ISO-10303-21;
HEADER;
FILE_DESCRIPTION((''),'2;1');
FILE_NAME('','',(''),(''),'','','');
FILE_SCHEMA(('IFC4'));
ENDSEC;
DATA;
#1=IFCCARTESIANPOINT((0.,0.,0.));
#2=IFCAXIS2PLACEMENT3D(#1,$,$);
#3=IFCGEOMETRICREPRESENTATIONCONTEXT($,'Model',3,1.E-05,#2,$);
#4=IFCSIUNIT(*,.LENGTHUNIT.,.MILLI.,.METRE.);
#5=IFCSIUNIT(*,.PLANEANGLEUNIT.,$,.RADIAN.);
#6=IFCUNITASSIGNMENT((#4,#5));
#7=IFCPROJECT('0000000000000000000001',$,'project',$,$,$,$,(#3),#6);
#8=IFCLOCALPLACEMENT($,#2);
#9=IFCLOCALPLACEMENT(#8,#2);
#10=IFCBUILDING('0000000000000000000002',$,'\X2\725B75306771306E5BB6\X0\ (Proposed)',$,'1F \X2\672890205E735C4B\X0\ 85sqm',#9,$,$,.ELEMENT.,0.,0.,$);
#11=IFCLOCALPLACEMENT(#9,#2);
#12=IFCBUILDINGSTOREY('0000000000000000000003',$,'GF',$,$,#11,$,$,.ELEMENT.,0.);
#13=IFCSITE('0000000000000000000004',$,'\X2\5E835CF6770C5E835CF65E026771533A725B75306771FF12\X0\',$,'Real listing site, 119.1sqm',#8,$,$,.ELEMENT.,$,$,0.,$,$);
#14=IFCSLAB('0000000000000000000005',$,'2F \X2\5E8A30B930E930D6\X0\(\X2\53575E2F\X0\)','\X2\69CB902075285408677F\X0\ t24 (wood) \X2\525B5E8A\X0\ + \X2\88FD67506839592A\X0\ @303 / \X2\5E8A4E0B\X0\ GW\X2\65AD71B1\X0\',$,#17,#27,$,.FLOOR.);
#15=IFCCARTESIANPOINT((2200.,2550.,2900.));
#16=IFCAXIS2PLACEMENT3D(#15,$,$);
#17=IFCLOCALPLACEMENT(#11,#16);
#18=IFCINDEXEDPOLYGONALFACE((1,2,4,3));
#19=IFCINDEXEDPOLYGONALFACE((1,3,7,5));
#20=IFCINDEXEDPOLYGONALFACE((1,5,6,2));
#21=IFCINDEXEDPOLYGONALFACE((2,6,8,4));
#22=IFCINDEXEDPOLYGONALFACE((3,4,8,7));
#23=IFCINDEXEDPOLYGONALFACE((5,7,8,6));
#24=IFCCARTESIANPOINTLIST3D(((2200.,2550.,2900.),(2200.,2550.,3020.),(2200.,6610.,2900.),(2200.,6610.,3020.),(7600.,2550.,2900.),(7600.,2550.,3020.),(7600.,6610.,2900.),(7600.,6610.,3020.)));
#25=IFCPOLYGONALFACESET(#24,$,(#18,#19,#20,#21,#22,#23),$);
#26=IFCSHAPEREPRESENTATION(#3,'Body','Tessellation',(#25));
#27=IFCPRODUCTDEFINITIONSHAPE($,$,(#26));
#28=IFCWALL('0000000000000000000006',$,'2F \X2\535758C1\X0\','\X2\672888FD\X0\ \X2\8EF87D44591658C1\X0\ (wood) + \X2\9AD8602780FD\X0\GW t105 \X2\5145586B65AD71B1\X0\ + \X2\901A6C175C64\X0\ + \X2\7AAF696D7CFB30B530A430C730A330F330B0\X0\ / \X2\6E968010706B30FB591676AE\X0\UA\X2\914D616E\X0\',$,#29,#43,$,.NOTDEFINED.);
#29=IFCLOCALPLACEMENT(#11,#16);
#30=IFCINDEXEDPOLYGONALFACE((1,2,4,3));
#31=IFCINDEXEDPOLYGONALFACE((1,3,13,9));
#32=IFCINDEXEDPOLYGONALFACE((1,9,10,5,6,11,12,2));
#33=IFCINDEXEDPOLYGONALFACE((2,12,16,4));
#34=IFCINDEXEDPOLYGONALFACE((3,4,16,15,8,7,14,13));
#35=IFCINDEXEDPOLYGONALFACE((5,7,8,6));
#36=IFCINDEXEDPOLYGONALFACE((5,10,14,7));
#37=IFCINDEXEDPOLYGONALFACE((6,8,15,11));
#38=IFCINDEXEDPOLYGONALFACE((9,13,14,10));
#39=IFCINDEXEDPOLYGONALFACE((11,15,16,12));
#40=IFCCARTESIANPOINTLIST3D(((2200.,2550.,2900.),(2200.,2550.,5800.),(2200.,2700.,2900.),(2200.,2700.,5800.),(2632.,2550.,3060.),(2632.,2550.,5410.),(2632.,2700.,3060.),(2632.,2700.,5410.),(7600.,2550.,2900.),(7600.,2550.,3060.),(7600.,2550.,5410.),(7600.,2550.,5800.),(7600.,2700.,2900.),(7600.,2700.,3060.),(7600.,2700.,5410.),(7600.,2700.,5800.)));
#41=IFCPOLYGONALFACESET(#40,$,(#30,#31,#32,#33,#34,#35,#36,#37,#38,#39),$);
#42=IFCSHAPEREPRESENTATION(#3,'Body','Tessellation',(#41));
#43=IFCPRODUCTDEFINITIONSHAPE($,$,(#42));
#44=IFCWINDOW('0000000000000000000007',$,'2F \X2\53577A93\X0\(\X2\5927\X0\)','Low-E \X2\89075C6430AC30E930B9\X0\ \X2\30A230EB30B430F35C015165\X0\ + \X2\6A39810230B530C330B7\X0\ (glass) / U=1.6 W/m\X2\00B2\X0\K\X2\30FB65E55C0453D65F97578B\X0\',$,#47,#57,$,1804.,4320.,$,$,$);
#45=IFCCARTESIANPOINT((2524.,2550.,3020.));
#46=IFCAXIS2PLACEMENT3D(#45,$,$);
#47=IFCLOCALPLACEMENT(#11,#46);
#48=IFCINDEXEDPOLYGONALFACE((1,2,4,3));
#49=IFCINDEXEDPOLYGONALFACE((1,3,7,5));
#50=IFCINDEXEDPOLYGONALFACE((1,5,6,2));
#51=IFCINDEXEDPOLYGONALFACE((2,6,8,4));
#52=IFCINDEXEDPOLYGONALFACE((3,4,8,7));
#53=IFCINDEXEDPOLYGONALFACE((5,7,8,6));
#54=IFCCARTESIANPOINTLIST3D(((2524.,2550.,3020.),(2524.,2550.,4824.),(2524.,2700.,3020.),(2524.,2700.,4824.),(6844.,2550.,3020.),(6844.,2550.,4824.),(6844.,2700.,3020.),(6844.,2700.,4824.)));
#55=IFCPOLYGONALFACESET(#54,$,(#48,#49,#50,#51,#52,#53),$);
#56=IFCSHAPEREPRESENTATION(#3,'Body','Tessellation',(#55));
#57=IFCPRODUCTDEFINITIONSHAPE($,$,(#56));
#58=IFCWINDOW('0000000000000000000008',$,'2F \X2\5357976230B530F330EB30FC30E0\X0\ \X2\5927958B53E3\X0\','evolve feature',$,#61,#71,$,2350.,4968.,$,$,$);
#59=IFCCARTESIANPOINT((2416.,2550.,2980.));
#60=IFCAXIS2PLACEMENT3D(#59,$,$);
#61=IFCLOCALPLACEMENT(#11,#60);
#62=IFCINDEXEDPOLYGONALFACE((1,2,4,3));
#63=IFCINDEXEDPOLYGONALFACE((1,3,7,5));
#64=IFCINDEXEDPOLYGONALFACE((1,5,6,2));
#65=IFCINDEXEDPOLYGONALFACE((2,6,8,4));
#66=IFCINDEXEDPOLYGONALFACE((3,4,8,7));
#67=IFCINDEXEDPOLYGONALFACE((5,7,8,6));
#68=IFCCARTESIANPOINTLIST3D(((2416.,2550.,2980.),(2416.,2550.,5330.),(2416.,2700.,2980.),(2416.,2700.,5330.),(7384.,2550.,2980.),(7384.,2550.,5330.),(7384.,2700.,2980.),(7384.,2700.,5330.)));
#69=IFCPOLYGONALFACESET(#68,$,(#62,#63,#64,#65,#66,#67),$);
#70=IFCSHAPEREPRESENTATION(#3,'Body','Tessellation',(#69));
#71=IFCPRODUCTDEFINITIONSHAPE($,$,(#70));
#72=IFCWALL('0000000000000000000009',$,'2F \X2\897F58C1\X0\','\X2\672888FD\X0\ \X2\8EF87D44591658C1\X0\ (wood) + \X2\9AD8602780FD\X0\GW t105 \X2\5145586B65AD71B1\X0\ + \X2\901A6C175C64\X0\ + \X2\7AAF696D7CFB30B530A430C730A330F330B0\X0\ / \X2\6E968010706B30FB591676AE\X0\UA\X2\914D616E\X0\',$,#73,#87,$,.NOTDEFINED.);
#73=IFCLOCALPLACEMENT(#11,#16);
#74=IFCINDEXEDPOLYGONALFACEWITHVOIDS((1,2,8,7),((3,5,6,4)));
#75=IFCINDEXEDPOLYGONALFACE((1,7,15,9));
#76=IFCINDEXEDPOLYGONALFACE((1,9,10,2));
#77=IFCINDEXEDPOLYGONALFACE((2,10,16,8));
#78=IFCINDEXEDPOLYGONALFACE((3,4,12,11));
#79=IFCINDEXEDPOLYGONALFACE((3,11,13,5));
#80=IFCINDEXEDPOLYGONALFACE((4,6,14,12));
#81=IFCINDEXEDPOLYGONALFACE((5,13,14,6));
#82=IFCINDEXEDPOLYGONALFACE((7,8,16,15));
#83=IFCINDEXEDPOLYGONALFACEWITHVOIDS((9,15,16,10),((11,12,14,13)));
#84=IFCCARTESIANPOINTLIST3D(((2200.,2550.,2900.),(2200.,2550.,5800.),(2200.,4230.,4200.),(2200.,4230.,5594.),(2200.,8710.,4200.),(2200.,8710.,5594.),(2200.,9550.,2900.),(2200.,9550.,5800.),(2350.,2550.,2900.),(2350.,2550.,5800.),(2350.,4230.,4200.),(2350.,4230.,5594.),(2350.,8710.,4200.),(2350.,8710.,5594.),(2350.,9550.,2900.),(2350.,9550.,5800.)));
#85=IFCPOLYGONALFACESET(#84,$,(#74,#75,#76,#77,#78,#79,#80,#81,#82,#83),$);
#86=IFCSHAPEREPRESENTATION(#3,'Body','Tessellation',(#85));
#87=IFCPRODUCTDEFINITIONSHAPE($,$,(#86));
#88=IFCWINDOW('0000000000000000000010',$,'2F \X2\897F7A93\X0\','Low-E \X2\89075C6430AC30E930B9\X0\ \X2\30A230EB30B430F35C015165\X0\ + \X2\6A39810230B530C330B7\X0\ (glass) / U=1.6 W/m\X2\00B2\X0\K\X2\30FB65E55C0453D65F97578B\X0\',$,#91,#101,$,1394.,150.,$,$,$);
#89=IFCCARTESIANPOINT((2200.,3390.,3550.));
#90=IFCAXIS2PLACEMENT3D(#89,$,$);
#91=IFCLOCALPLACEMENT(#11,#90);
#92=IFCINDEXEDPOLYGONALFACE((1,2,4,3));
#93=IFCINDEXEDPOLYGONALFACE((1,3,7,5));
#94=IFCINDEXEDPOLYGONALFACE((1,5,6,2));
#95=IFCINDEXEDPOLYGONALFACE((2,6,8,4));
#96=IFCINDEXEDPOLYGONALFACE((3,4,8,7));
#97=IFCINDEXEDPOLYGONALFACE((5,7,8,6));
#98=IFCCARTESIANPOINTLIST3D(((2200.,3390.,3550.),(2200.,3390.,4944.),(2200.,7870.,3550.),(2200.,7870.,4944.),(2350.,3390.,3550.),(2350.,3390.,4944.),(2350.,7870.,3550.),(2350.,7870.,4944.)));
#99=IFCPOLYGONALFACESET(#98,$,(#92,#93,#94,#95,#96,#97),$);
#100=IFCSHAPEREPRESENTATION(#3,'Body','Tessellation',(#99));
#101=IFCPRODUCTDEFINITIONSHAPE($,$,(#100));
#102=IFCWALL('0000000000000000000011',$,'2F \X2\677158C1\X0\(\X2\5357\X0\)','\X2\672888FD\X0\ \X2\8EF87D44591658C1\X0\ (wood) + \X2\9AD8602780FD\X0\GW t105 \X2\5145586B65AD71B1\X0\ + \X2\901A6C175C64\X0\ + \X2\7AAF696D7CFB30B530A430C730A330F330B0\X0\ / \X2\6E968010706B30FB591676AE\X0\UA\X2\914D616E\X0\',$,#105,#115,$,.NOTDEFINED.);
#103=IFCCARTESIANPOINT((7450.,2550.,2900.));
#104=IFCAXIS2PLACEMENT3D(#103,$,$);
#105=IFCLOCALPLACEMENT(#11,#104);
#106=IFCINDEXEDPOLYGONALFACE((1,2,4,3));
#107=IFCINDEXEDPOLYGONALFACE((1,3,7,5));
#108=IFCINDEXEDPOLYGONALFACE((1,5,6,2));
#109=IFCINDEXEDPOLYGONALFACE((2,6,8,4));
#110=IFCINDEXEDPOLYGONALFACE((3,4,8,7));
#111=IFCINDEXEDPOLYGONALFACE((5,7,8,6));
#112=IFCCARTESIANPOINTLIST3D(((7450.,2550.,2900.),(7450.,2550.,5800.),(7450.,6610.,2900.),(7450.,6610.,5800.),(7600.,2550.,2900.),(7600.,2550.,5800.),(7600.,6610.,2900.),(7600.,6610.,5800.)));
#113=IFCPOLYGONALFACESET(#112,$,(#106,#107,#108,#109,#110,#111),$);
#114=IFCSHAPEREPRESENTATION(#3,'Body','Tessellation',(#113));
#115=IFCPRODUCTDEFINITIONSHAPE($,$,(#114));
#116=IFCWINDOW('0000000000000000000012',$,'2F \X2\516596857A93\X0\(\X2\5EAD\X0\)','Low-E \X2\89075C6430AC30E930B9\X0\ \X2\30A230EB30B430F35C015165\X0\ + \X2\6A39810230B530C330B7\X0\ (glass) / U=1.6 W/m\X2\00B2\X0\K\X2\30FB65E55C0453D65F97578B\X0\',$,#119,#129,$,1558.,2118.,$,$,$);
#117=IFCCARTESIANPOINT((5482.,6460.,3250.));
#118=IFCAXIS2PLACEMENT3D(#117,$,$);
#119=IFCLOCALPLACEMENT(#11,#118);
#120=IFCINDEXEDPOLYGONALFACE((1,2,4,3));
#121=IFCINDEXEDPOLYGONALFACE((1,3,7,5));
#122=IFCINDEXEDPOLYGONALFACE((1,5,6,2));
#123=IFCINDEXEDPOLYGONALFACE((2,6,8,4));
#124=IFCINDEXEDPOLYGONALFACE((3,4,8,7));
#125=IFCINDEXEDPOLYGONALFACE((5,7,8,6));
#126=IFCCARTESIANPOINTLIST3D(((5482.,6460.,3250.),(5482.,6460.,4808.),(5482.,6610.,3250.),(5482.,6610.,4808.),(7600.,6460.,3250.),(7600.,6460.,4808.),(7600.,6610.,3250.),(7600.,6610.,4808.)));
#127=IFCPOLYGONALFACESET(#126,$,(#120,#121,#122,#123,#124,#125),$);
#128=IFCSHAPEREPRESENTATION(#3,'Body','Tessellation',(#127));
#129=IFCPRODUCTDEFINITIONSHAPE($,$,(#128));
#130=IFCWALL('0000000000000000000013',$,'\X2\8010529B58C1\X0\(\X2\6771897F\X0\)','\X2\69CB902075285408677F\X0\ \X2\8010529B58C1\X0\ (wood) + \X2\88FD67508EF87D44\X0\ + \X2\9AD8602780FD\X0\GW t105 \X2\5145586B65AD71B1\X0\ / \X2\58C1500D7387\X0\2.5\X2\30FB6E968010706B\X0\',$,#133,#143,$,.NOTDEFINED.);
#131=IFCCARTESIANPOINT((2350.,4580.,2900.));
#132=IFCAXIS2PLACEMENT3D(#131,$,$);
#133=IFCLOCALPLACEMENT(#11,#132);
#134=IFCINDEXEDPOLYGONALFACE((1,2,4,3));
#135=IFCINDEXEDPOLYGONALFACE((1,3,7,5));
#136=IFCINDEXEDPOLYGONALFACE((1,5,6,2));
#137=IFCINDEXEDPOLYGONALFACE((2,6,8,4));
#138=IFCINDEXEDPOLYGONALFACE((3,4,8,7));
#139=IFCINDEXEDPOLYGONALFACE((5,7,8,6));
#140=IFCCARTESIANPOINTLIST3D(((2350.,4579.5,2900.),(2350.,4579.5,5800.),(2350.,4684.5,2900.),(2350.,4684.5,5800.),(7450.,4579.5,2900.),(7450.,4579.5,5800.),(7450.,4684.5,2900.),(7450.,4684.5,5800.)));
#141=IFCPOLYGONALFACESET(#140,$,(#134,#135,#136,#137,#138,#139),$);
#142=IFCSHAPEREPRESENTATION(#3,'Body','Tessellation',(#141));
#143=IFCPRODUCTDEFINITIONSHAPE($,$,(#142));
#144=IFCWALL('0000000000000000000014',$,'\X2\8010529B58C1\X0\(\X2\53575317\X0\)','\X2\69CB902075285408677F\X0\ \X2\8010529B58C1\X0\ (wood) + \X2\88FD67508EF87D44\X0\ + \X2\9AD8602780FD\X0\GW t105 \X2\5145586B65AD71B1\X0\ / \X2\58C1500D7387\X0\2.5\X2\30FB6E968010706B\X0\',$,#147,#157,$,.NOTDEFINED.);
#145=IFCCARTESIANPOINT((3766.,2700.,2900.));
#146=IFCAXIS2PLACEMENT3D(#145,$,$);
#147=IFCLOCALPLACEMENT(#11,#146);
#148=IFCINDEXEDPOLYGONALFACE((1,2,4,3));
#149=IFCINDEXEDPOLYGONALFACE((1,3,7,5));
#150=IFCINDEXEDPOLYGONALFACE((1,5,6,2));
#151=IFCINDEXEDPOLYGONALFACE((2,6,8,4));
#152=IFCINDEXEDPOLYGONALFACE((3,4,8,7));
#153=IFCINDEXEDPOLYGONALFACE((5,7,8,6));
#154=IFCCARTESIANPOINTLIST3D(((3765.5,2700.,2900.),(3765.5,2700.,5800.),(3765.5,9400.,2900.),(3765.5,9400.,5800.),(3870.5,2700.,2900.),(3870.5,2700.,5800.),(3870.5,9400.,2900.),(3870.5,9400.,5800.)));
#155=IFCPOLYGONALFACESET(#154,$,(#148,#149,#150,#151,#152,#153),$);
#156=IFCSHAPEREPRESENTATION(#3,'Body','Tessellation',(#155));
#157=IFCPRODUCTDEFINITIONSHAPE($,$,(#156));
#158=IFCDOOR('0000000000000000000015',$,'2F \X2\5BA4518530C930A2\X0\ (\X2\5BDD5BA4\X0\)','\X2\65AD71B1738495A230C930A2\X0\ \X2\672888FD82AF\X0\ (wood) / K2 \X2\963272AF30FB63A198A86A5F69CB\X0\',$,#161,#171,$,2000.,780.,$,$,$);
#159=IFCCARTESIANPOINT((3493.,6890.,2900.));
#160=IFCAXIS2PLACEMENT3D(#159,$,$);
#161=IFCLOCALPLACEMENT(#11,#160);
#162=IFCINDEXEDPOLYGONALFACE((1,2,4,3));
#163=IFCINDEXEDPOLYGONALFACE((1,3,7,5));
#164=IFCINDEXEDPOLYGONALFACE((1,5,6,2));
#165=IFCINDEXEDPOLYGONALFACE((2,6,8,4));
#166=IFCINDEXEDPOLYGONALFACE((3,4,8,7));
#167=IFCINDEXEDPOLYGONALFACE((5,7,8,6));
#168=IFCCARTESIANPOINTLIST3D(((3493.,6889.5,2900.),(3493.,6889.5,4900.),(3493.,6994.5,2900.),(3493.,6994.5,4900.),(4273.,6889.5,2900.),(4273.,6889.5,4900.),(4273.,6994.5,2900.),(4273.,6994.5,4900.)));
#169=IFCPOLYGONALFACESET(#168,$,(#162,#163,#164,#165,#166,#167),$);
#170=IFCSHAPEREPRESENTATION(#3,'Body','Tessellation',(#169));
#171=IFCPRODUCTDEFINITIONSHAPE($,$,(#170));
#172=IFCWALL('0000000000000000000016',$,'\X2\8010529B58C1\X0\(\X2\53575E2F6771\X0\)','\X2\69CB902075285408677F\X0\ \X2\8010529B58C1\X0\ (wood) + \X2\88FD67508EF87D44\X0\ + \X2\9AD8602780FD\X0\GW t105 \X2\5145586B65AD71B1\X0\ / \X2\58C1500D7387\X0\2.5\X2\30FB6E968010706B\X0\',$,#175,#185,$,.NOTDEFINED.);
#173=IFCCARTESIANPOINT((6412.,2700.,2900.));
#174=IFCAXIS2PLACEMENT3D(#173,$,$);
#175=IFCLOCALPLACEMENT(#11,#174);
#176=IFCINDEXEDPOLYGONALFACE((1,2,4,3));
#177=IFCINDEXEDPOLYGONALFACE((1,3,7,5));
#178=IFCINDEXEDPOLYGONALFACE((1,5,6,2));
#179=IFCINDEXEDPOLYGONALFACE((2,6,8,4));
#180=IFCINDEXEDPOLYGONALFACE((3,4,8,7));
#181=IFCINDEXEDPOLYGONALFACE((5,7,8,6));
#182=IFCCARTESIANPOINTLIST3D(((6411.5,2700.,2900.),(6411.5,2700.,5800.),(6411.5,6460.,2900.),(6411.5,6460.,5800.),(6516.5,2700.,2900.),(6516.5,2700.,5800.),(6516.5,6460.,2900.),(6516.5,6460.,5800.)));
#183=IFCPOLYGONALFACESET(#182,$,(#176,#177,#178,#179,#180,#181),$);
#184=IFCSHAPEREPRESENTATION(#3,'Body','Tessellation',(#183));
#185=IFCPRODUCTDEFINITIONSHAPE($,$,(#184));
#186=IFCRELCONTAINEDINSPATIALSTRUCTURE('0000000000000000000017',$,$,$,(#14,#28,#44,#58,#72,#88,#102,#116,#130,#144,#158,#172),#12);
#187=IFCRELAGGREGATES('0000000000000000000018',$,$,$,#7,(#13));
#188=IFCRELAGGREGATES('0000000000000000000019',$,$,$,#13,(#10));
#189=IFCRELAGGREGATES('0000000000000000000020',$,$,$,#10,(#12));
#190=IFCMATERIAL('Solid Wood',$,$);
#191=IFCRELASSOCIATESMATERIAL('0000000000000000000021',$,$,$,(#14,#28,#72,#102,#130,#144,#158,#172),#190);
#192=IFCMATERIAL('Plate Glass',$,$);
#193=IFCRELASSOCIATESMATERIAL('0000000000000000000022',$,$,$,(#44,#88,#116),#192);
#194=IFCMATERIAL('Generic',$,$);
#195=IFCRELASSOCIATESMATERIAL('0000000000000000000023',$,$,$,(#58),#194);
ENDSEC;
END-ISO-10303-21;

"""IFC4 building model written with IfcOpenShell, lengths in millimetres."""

from ifc_helpers import new_model, si_unit, frame, frame_2d, origin, place, context, project, spatial, rectangle, extrude, material, element, fill, save


model = new_model("IFC4")

# Units and contexts
model_context = context("Model", 3, precision=1e-05, world=origin())
ifc_project = project(units=[si_unit("LENGTHUNIT", "METRE", prefix="MILLI"), si_unit("PLANEANGLEUNIT", "RADIAN")], contexts=[model_context])

# Site, building, storey
site_placement = place(None, origin())
site = spatial("IfcSite", under=ifc_project, at=site_placement, Name="広島県広島市東区牛田東２", ObjectType="Real listing site, 119.1sqm", CompositionType="ELEMENT", RefElevation=0.0)
building_placement = place(site_placement, origin())
building = spatial("IfcBuilding", under=site, at=building_placement, Name="牛田東の家 (Proposed)", ObjectType="1F 木造平屋 85sqm", CompositionType="ELEMENT", ElevationOfRefHeight=0.0, ElevationOfTerrain=0.0)
storey_placement = place(building_placement, origin())
storey = spatial("IfcBuildingStorey", under=building, at=storey_placement, Name="GF", CompositionType="ELEMENT", Elevation=0.0)

# Slab
ifc_material_1 = material(Name="Solid Wood")
slab_placement = place(storey_placement, frame((2200.0, 2550.0, 2900.0)))
element("IfcSlab", 1, at=slab_placement, inside=storey, material=ifc_material_1, Name="2F 床スラブ(南帯)", Description="構造用合板 t24 (wood) 剛床 + 製材根太 @303 / 床下 GW断熱", PredefinedType="FLOOR", context=model_context, shape_type="SweptSolid", body=[
    extrude(rectangle(XDim=5400.0, YDim=4060.0, at=frame_2d((2700.0, 2030.0))), frame((2200.0, 2550.0, 2900.0)), (0.0, 0.0, 1.0), 120.0),
])

# Wall, openings, windows
wall_1_placement = place(storey_placement, frame((2200.0, 2550.0, 2900.0)))
wall_1 = element("IfcWall", 2, at=wall_1_placement, inside=storey, material=ifc_material_1, Name="2F 南壁", Description="木製 軸組外壁 (wood) + 高性能GW t105 充填断熱 + 通気層 + 窯業系サイディング / 準耐火・外皮UA配慮", PredefinedType="NOTDEFINED", context=model_context, shape_type="SweptSolid", body=[
    extrude(rectangle(XDim=5400.0, YDim=150.0, at=frame_2d((2700.0, 75.0))), frame((2200.0, 2550.0, 2900.0)), (0.0, 0.0, 1.0), 2900.0),
])
opening_1_placement = place(storey_placement, frame((2524.0, 2550.0, 3020.0)))
opening_1 = element("IfcOpeningElement", 3, at=opening_1_placement, cuts=wall_1, PredefinedType="NOTDEFINED", context=model_context, shape_type="SweptSolid", body=[
    extrude(rectangle(XDim=4320.0, YDim=150.0, at=frame_2d((2160.0, 75.0))), frame((2524.0, 2550.0, 3020.0)), (0.0, 0.0, 1.0), 1804.0),
])
opening_2_placement = place(storey_placement, frame((2416.0, 2550.0, 2980.0)))
opening_2 = element("IfcOpeningElement", 4, at=opening_2_placement, cuts=wall_1, PredefinedType="NOTDEFINED", context=model_context, shape_type="SweptSolid", body=[
    extrude(rectangle(XDim=4968.0, YDim=150.0, at=frame_2d((2484.0, 75.0))), frame((2416.0, 2550.0, 2980.0)), (0.0, 0.0, 1.0), 2350.0),
])
ifc_material_2 = material(Name="Plate Glass")
window_1_placement = place(storey_placement, frame((2524.0, 2550.0, 3020.0)))
window_1 = element("IfcWindow", 5, at=window_1_placement, inside=storey, material=ifc_material_2, Name="2F 南窓(大)", Description="Low-E 複層ガラス アルゴン封入 + 樹脂サッシ (glass) / U=1.6 W/m²K・日射取得型", OverallHeight=1804.0, OverallWidth=4320.0, context=model_context, shape_type="SweptSolid", body=[
    extrude(rectangle(XDim=4320.0, YDim=150.0, at=frame_2d((2160.0, 75.0))), frame((2524.0, 2550.0, 3020.0)), (0.0, 0.0, 1.0), 1804.0),
])
fill(opening_1, window_1)
ifc_material_3 = material(Name="Generic")
window_2_placement = place(storey_placement, frame((2416.0, 2550.0, 2980.0)))
window_2 = element("IfcWindow", 6, at=window_2_placement, inside=storey, material=ifc_material_3, Name="2F 南面サンルーム 大開口", Description="evolve feature", OverallHeight=2350.0, OverallWidth=4968.0, context=model_context, shape_type="SweptSolid", body=[
    extrude(rectangle(XDim=4968.0, YDim=150.0, at=frame_2d((2484.0, 75.0))), frame((2416.0, 2550.0, 2980.0)), (0.0, 0.0, 1.0), 2350.0),
])
fill(opening_2, window_2)

# Walls, openings, windows
wall_2_placement = place(storey_placement, frame((2200.0, 2550.0, 2900.0)))
wall_2 = element("IfcWall", 7, at=wall_2_placement, inside=storey, material=ifc_material_1, Name="2F 西壁", Description="木製 軸組外壁 (wood) + 高性能GW t105 充填断熱 + 通気層 + 窯業系サイディング / 準耐火・外皮UA配慮", PredefinedType="NOTDEFINED", context=model_context, shape_type="SweptSolid", body=[
    extrude(rectangle(XDim=150.0, YDim=7000.0, at=frame_2d((75.0, 3500.0))), frame((2200.0, 2550.0, 2900.0)), (0.0, 0.0, 1.0), 2900.0),
])
opening_3_placement = place(storey_placement, frame((2200.0, 3390.0, 3550.0)))
opening_3 = element("IfcOpeningElement", 8, at=opening_3_placement, cuts=wall_2, PredefinedType="NOTDEFINED", context=model_context, shape_type="SweptSolid", body=[
    extrude(rectangle(XDim=150.0, YDim=4480.0, at=frame_2d((75.0, 2240.0))), frame((2200.0, 3390.0, 3550.0)), (0.0, 0.0, 1.0), 1394.0),
])
window_3_placement = place(storey_placement, frame((2200.0, 3390.0, 3550.0)))
window_3 = element("IfcWindow", 9, at=window_3_placement, inside=storey, material=ifc_material_2, Name="2F 西窓", Description="Low-E 複層ガラス アルゴン封入 + 樹脂サッシ (glass) / U=1.6 W/m²K・日射取得型", OverallHeight=1394.0, OverallWidth=150.0, context=model_context, shape_type="SweptSolid", body=[
    extrude(rectangle(XDim=150.0, YDim=4480.0, at=frame_2d((75.0, 2240.0))), frame((2200.0, 3390.0, 3550.0)), (0.0, 0.0, 1.0), 1394.0),
])
fill(opening_3, window_3)
wall_3_placement = place(storey_placement, frame((7450.0, 2550.0, 2900.0)))
wall_3 = element("IfcWall", 10, at=wall_3_placement, inside=storey, material=ifc_material_1, Name="2F 東壁(南)", Description="木製 軸組外壁 (wood) + 高性能GW t105 充填断熱 + 通気層 + 窯業系サイディング / 準耐火・外皮UA配慮", PredefinedType="NOTDEFINED", context=model_context, shape_type="SweptSolid", body=[
    extrude(rectangle(XDim=150.0, YDim=4060.0, at=frame_2d((75.0, 2030.0))), frame((7450.0, 2550.0, 2900.0)), (0.0, 0.0, 1.0), 2900.0),
])
opening_4_placement = place(storey_placement, frame((5482.0, 6460.0, 3250.0)))
opening_4 = element("IfcOpeningElement", 11, at=opening_4_placement, cuts=wall_3, PredefinedType="NOTDEFINED", context=model_context, shape_type="SweptSolid", body=[
    extrude(rectangle(XDim=2118.0, YDim=150.0, at=frame_2d((1059.0, 75.0))), frame((5482.0, 6460.0, 3250.0)), (0.0, 0.0, 1.0), 1558.0),
])
window_4_placement = place(storey_placement, frame((5482.0, 6460.0, 3250.0)))
window_4 = element("IfcWindow", 12, at=window_4_placement, inside=storey, material=ifc_material_2, Name="2F 入隅窓(庭)", Description="Low-E 複層ガラス アルゴン封入 + 樹脂サッシ (glass) / U=1.6 W/m²K・日射取得型", OverallHeight=1558.0, OverallWidth=2118.0, context=model_context, shape_type="SweptSolid", body=[
    extrude(rectangle(XDim=2118.0, YDim=150.0, at=frame_2d((1059.0, 75.0))), frame((5482.0, 6460.0, 3250.0)), (0.0, 0.0, 1.0), 1558.0),
])
fill(opening_4, window_4)

# Wall
wall_4_placement = place(storey_placement, frame((2350.0, 4580.0, 2900.0)))
element("IfcWall", 13, at=wall_4_placement, inside=storey, material=ifc_material_1, Name="耐力壁(東西)", Description="構造用合板 耐力壁 (wood) + 製材軸組 + 高性能GW t105 充填断熱 / 壁倍率2.5・準耐火", PredefinedType="NOTDEFINED", context=model_context, shape_type="SweptSolid", body=[
    extrude(rectangle(XDim=5100.0, YDim=105.0, at=frame_2d((2550.0, 52.0))), frame((2350.0, 4580.0, 2900.0)), (0.0, 0.0, 1.0), 2900.0),
])

# Wall, opening, door
wall_5_placement = place(storey_placement, frame((3766.0, 2700.0, 2900.0)))
wall_5 = element("IfcWall", 14, at=wall_5_placement, inside=storey, material=ifc_material_1, Name="耐力壁(南北)", Description="構造用合板 耐力壁 (wood) + 製材軸組 + 高性能GW t105 充填断熱 / 壁倍率2.5・準耐火", PredefinedType="NOTDEFINED", context=model_context, shape_type="SweptSolid", body=[
    extrude(rectangle(XDim=105.0, YDim=6700.0, at=frame_2d((52.0, 3350.0))), frame((3766.0, 2700.0, 2900.0)), (0.0, 0.0, 1.0), 2900.0),
])
opening_5_placement = place(storey_placement, frame((3493.0, 6890.0, 2900.0)))
opening_5 = element("IfcOpeningElement", 15, at=opening_5_placement, cuts=wall_5, PredefinedType="NOTDEFINED", context=model_context, shape_type="SweptSolid", body=[
    extrude(rectangle(XDim=780.0, YDim=105.0, at=frame_2d((390.0, 52.0))), frame((3493.0, 6890.0, 2900.0)), (0.0, 0.0, 1.0), 2000.0),
])
door_placement = place(storey_placement, frame((3493.0, 6890.0, 2900.0)))
door = element("IfcDoor", 16, at=door_placement, inside=storey, material=ifc_material_1, Name="2F 室内ドア (寝室)", Description="断熱玄関ドア 木製芯 (wood) / K2 防犯・採風機構", OverallHeight=2000.0, OverallWidth=780.0, context=model_context, shape_type="SweptSolid", body=[
    extrude(rectangle(XDim=780.0, YDim=105.0, at=frame_2d((390.0, 52.0))), frame((3493.0, 6890.0, 2900.0)), (0.0, 0.0, 1.0), 2000.0),
])
fill(opening_5, door)

# Wall
wall_6_placement = place(storey_placement, frame((6412.0, 2700.0, 2900.0)))
element("IfcWall", 17, at=wall_6_placement, inside=storey, material=ifc_material_1, Name="耐力壁(南帯東)", Description="構造用合板 耐力壁 (wood) + 製材軸組 + 高性能GW t105 充填断熱 / 壁倍率2.5・準耐火", PredefinedType="NOTDEFINED", context=model_context, shape_type="SweptSolid", body=[
    extrude(rectangle(XDim=105.0, YDim=3760.0, at=frame_2d((52.0, 1880.0))), frame((6412.0, 2700.0, 2900.0)), (0.0, 0.0, 1.0), 2900.0),
])

save(model, "model.ifc")
